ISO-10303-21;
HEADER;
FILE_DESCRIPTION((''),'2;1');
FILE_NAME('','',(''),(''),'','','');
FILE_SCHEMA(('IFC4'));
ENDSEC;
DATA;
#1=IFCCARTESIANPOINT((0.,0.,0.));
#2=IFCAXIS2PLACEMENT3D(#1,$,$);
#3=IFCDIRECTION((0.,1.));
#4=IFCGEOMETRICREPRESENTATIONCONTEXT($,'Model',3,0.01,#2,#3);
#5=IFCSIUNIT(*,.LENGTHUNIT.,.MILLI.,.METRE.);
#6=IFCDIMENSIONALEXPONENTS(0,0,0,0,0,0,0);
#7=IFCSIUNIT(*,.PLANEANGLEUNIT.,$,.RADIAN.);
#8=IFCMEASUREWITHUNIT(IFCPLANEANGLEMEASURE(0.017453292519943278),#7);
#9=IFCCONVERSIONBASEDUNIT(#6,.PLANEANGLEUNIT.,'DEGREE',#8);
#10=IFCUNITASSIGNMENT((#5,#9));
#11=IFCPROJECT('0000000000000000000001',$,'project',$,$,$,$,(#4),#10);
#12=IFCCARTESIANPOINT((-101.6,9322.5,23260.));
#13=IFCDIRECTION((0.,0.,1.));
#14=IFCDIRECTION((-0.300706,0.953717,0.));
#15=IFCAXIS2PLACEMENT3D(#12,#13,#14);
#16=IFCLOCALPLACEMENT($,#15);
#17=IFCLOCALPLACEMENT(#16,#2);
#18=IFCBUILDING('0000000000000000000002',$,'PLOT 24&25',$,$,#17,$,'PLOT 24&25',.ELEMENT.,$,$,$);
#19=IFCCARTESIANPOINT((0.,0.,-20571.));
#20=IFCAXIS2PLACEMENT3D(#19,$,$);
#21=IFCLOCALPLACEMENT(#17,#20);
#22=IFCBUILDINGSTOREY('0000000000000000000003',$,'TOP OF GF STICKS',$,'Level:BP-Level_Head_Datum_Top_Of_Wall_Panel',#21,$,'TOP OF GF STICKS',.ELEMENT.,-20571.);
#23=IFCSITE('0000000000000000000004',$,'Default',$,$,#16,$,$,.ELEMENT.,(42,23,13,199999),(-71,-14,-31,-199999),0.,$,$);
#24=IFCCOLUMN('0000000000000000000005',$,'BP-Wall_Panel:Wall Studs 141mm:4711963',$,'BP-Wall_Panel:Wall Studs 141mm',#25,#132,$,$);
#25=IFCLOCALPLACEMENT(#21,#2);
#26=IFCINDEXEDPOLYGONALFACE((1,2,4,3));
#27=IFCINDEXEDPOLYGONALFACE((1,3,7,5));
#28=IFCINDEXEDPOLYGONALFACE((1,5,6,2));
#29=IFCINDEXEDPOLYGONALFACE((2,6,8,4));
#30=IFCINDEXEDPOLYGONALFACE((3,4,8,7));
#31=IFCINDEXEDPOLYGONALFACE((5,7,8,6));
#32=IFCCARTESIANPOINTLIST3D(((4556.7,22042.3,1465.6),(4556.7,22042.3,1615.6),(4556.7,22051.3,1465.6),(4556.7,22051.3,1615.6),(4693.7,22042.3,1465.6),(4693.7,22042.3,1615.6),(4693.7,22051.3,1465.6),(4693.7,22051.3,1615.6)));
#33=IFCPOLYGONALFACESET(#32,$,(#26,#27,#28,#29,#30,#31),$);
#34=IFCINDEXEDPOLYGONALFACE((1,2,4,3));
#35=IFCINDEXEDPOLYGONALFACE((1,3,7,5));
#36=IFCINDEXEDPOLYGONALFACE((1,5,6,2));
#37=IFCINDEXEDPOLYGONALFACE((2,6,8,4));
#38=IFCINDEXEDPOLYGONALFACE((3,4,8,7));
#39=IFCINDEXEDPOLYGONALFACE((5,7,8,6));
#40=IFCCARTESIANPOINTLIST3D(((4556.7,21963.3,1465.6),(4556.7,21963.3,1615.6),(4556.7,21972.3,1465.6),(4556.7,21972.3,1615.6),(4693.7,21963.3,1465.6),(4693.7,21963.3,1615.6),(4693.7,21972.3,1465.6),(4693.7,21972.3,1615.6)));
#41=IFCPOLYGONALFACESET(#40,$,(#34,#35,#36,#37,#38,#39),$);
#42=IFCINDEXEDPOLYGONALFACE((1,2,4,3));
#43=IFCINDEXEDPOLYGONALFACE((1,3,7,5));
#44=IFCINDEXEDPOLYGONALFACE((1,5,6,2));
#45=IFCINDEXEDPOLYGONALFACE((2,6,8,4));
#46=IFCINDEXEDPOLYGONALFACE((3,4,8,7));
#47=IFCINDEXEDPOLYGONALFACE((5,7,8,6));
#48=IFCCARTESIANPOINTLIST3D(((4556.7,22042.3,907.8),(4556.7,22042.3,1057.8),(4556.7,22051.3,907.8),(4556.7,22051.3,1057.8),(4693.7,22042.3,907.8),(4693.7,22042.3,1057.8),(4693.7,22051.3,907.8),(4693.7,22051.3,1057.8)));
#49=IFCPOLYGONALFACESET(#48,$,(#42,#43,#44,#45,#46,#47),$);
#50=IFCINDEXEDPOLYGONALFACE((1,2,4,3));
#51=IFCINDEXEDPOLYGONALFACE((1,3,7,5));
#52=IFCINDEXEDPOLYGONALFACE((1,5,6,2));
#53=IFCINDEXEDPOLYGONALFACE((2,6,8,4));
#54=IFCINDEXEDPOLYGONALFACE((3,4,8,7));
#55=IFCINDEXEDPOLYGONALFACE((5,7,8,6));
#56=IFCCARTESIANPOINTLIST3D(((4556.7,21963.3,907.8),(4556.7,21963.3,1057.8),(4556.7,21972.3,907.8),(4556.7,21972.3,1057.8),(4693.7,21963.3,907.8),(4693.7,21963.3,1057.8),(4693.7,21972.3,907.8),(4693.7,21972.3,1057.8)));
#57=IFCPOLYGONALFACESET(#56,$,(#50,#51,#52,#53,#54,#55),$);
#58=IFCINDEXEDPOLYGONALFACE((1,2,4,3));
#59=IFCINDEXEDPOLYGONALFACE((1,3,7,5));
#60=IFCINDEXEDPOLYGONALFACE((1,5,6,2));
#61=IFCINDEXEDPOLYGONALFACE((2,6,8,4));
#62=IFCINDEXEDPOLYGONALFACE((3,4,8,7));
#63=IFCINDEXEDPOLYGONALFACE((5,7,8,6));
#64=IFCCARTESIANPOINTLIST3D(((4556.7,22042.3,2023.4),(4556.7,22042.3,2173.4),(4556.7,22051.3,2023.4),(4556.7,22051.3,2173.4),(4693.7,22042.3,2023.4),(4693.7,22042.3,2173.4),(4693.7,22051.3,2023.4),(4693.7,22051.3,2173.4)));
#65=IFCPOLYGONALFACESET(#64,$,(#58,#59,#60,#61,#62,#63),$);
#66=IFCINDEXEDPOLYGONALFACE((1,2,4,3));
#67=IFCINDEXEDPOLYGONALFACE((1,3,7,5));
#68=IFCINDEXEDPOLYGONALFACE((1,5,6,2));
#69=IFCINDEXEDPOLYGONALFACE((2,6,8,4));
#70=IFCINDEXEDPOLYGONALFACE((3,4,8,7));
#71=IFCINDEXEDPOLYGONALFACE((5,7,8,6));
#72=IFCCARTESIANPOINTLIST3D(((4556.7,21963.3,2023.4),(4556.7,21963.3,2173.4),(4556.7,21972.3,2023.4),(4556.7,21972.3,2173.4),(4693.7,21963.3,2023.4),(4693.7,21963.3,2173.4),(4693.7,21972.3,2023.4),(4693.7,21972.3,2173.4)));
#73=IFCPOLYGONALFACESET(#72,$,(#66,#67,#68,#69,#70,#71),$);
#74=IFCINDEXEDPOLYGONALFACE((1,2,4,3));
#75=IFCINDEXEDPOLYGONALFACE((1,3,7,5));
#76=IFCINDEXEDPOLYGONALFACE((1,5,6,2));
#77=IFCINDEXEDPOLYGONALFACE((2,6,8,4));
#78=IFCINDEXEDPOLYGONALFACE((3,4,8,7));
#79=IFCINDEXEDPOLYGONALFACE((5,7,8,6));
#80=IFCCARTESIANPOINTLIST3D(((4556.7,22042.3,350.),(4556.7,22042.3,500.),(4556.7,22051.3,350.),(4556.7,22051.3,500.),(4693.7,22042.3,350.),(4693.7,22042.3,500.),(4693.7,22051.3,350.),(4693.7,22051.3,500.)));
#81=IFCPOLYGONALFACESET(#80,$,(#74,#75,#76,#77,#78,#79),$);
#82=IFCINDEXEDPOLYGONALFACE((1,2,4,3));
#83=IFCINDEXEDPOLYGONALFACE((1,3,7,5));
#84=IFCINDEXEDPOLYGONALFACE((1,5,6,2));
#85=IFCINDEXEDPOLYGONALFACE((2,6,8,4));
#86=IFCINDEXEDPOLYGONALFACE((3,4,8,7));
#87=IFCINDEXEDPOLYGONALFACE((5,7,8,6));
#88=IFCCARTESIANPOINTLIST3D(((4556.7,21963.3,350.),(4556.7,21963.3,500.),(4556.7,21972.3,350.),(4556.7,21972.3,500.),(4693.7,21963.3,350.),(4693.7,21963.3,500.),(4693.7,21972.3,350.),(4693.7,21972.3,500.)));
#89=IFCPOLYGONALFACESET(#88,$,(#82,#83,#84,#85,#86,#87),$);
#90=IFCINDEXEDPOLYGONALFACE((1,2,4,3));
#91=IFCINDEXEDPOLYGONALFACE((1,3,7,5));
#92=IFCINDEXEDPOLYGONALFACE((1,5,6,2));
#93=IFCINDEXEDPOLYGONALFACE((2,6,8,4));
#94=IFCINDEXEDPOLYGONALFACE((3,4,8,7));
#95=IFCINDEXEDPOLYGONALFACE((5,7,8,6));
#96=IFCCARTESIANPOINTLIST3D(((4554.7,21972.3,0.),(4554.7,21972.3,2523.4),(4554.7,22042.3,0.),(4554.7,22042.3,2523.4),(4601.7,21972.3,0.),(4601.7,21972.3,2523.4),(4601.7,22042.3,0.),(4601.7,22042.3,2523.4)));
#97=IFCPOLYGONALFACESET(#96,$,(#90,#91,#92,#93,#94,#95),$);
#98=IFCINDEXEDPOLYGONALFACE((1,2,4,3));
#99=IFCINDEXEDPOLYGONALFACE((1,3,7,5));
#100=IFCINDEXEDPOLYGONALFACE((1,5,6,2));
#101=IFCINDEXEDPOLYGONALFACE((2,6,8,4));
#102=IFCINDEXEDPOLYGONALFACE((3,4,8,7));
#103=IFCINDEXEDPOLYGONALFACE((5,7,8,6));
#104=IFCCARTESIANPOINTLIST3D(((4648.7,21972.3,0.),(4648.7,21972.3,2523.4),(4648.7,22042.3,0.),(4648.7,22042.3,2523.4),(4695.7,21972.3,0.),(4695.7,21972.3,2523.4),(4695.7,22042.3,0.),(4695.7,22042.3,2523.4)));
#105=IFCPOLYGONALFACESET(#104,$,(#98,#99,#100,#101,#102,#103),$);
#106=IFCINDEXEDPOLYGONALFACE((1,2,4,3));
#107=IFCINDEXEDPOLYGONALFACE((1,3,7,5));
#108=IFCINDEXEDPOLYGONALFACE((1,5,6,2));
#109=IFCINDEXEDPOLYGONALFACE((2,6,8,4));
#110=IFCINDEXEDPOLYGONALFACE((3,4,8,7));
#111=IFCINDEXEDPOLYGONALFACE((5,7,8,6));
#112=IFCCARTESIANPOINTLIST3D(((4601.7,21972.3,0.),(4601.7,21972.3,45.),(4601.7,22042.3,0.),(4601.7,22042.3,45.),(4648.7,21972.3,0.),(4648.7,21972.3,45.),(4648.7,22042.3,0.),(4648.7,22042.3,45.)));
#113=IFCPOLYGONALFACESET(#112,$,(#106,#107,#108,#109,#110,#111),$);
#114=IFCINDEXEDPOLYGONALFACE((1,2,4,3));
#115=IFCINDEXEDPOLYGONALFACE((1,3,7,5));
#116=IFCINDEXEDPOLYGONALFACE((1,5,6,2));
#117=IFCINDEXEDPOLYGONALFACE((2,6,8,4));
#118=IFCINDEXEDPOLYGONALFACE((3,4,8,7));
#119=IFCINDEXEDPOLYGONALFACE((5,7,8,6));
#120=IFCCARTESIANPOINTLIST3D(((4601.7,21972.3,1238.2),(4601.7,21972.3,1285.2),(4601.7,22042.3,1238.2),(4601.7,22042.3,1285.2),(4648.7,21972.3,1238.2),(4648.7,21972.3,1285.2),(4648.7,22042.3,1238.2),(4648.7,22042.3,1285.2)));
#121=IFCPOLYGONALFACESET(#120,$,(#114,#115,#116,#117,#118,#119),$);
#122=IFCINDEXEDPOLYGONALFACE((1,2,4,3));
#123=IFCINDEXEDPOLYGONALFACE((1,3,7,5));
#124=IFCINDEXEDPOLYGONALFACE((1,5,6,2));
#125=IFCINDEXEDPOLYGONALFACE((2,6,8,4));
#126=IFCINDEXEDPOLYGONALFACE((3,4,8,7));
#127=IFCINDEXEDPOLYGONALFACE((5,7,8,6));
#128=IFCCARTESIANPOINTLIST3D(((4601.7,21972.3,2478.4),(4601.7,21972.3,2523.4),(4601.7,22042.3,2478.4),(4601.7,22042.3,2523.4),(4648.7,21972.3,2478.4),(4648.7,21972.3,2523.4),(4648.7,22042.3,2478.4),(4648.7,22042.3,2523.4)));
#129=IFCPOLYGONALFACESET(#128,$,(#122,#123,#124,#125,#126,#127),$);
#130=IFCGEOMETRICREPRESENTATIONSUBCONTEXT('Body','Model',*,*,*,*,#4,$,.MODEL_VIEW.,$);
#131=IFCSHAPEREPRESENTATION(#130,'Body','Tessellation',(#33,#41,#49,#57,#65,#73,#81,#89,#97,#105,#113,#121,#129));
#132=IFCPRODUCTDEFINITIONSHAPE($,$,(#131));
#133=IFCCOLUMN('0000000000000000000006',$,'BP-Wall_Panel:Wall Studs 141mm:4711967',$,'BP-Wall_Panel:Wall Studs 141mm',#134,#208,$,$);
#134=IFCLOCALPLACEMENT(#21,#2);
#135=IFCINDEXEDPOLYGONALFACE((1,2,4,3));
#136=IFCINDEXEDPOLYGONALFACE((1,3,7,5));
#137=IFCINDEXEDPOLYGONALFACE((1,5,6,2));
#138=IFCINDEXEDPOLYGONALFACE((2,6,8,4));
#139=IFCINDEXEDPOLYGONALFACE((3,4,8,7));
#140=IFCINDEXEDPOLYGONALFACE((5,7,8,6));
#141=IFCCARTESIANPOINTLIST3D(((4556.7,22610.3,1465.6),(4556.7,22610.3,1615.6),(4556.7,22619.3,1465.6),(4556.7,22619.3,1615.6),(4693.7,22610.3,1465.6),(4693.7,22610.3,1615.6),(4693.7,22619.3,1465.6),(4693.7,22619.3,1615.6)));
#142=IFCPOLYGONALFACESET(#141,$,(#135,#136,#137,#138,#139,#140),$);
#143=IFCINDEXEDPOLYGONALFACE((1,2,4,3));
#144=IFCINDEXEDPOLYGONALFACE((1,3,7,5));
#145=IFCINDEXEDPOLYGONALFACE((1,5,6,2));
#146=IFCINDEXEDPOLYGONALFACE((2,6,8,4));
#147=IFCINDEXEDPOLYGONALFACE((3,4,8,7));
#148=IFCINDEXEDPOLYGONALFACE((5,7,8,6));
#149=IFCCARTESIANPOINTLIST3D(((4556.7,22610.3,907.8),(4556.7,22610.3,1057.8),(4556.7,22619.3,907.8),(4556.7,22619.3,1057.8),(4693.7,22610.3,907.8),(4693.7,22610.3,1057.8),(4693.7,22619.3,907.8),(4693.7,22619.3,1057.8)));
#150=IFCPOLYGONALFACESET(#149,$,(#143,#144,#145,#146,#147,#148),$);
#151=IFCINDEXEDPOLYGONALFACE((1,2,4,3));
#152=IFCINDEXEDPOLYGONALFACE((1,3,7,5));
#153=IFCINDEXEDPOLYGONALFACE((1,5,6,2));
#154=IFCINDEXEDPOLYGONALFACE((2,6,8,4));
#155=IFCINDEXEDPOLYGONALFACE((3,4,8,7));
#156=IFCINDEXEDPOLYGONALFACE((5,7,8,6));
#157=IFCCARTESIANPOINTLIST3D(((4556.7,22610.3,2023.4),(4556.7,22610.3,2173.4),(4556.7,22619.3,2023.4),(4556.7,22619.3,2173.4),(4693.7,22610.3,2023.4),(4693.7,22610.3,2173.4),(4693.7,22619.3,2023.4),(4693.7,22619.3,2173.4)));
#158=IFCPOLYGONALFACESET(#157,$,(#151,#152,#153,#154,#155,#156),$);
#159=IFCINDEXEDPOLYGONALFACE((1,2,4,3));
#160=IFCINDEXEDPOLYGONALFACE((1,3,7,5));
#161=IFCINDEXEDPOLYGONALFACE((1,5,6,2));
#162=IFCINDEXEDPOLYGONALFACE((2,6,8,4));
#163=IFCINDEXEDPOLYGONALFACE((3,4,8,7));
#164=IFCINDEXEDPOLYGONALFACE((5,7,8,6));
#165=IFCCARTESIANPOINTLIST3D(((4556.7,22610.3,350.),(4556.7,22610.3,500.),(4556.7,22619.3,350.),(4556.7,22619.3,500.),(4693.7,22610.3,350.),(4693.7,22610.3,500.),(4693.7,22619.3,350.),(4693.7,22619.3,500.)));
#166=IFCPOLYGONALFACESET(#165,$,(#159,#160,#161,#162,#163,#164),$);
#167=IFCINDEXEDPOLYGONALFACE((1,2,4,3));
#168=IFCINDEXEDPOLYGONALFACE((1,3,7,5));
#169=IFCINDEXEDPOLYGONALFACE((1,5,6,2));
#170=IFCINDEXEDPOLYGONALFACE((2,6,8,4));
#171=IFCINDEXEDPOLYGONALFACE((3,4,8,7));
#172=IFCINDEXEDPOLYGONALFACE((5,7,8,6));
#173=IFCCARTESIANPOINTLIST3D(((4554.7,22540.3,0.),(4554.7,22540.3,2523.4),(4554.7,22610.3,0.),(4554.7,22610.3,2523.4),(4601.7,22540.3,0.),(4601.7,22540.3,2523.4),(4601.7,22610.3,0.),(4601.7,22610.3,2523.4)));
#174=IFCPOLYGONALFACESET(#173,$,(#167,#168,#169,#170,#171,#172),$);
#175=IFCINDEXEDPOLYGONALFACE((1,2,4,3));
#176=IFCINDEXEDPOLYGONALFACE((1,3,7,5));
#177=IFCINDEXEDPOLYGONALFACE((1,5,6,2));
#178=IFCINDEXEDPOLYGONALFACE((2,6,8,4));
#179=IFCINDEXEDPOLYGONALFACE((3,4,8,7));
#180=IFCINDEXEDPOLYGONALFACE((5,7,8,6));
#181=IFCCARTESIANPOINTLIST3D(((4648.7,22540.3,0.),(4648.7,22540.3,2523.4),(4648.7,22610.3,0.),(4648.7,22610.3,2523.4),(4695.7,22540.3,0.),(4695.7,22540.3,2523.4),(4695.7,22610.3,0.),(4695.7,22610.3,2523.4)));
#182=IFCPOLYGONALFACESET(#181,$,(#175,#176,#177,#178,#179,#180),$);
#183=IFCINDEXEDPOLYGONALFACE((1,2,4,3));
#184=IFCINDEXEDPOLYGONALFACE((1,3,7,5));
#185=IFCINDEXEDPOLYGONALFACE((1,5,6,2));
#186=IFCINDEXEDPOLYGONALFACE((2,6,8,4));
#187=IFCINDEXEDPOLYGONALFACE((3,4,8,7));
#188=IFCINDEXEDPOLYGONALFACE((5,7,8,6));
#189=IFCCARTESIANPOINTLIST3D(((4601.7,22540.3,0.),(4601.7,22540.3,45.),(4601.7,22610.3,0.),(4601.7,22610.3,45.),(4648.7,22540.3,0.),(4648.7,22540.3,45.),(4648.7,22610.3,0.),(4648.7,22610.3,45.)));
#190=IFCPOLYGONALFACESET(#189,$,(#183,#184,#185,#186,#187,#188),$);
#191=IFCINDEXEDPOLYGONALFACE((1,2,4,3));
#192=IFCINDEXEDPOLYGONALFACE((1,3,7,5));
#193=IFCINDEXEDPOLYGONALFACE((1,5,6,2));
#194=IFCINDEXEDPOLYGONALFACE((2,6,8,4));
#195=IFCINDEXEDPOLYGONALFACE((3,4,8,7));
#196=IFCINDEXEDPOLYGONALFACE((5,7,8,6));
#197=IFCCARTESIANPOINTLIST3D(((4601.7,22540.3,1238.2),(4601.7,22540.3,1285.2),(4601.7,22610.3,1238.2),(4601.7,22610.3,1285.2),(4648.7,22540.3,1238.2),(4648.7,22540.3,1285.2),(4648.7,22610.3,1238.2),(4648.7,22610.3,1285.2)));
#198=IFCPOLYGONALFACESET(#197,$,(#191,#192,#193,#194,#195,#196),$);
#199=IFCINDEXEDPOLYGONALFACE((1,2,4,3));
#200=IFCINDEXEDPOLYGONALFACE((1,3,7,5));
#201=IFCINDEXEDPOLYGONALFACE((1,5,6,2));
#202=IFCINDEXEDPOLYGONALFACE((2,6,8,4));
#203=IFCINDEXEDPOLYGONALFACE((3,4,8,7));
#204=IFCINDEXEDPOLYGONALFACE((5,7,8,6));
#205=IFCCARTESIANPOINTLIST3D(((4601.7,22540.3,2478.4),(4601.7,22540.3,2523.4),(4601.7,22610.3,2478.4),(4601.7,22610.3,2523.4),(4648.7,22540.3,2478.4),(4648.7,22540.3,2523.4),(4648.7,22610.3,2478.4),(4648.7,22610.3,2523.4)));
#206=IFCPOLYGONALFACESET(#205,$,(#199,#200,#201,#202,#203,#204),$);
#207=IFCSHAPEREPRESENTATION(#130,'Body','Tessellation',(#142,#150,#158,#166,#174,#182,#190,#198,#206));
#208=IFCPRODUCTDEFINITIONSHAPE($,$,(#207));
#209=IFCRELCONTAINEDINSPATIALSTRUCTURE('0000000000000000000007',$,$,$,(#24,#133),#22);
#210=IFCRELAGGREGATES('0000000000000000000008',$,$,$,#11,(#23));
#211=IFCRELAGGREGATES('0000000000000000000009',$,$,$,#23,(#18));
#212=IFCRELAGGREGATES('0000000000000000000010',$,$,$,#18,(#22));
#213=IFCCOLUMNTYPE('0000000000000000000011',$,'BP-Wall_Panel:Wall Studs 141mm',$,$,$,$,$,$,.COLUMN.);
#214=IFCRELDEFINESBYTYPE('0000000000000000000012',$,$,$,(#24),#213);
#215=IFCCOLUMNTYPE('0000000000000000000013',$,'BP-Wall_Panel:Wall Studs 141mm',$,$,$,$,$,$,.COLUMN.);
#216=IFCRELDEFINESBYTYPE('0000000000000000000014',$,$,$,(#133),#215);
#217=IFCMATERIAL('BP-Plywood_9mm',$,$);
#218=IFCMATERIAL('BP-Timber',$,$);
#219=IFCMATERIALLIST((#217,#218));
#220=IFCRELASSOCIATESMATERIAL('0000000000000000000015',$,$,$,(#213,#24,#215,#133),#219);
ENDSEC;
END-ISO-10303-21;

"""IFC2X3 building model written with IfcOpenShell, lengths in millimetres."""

from ifc_helpers import new_model, entity, si_unit, converted_unit, direction, frame, frame_2d, origin, origin_2d_with_axis, place, context, subcontext, project, spatial, rectangle, extrude, source, transform, mapped, material, material_list, type_object, type_shapes, element, save


model = new_model("IFC2X3")

# Units and contexts
model_context = context("Model", 3, precision=0.01, world=origin(), true_north=direction((0.0, 1.0)))
body_context = subcontext(model_context, "Body", "Model", "MODEL_VIEW")
ifc_project = project(units=[si_unit("LENGTHUNIT", "METRE", prefix="MILLI"), converted_unit("PLANEANGLEUNIT", "DEGREE", entity("IfcPlaneAngleMeasure", 0.017453292519943278), si_unit("PLANEANGLEUNIT", "RADIAN"), dimensions=[0, 0, 0, 0, 0, 0, 0])], contexts=[model_context])

# Site, building, storey
site_placement = place(None, frame((-101.6, 9322.5, 23260.0), z_axis=(0.0, 0.0, 1.0), x_axis=(-0.300706, 0.953717, 0.0)))
site = spatial("IfcSite", under=ifc_project, at=site_placement, Name="Default", CompositionType="ELEMENT", RefLatitude=(42, 23, 13, 199999), RefLongitude=(-71, -14, -31, -199999), RefElevation=0.0)
building_placement = place(site_placement, origin())
building = spatial("IfcBuilding", under=site, at=building_placement, Name="PLOT 24&25", LongName="PLOT 24&25", CompositionType="ELEMENT")
storey_placement = place(building_placement, frame((0.0, 0.0, -20571.0)))
storey = spatial("IfcBuildingStorey", under=building, at=storey_placement, Name="TOP OF GF STICKS", ObjectType="Level:BP-Level_Head_Datum_Top_Of_Wall_Panel", LongName="TOP OF GF STICKS", CompositionType="ELEMENT", Elevation=-20571.0)

# Columns
ifc_material_1 = material(Name="BP-Plywood_9mm")
ifc_material_2 = material(Name="BP-Timber")
ifc_material_list = material_list([ifc_material_1, ifc_material_2])
column_type_1 = type_object("IfcColumnType", Name="BP-Wall_Panel:Wall Studs 141mm", PredefinedType="COLUMN", material=ifc_material_list)
shared_shape_1 = source(origin(), body_context, "Body", "SweptSolid", [
    extrude(rectangle(XDim=9.0, YDim=137.0, at=origin_2d_with_axis()), frame((39.5, 0.0, -19105.4)), (0.0, 0.0, 1.0), 150.0),
    extrude(rectangle(XDim=137.0, YDim=9.0, at=origin_2d_with_axis()), frame((-39.5, 0.0, -19105.4), z_axis=(0.0, 0.0, 1.0), x_axis=(0.0, 1.0, 0.0)), (0.0, 0.0, 1.0), 150.0),
    extrude(rectangle(XDim=9.0, YDim=137.0, at=origin_2d_with_axis()), frame((39.5, 0.0, -19663.2)), (0.0, 0.0, 1.0), 150.0),
    extrude(rectangle(XDim=137.0, YDim=9.0, at=origin_2d_with_axis()), frame((-39.5, 0.0, -19663.2), z_axis=(0.0, 0.0, 1.0), x_axis=(0.0, 1.0, 0.0)), (0.0, 0.0, 1.0), 150.0),
    extrude(rectangle(XDim=9.0, YDim=137.0, at=frame_2d((0.0, 0.0), x_axis=(1.0, 0.0))), frame((39.5, 0.0, -18547.6)), (0.0, 0.0, 1.0), 150.0),
    extrude(rectangle(XDim=137.0, YDim=9.0, at=origin_2d_with_axis()), frame((-39.5, 0.0, -18547.6), z_axis=(0.0, 0.0, 1.0), x_axis=(0.0, 1.0, 0.0)), (0.0, 0.0, 1.0), 150.0),
    extrude(rectangle(XDim=9.0, YDim=137.0, at=origin_2d_with_axis()), frame((39.5, 0.0, -20221.0)), (0.0, 0.0, 1.0), 150.0),
    extrude(rectangle(XDim=137.0, YDim=9.0, at=origin_2d_with_axis()), frame((-39.5, 0.0, -20221.0), z_axis=(0.0, 0.0, 1.0), x_axis=(0.0, 1.0, 0.0)), (0.0, 0.0, 1.0), 150.0),
    extrude(rectangle(XDim=47.0, YDim=70.0, at=origin_2d_with_axis()), frame((0.0, 47.0, -20571.0), z_axis=(0.0, 0.0, 1.0), x_axis=(0.0, 1.0, 0.0)), (0.0, 0.0, 1.0), 2523.4),
    extrude(rectangle(XDim=47.0, YDim=70.0, at=origin_2d_with_axis()), frame((0.0, -47.0, -20571.0), z_axis=(0.0, 0.0, 1.0), x_axis=(0.0, 1.0, 0.0)), (0.0, 0.0, 1.0), 2523.4),
    extrude(rectangle(XDim=70.0, YDim=47.0, at=origin_2d_with_axis()), frame((0.0, 0.0, -20571.0)), (0.0, 0.0, 1.0), 45.0),
    extrude(rectangle(XDim=70.0, YDim=47.0, at=origin_2d_with_axis()), frame((0.0, 0.0, -19332.8)), (0.0, 0.0, 1.0), 47.0),
    extrude(rectangle(XDim=70.0, YDim=47.0, at=origin_2d_with_axis()), frame((0.0, 0.0, -18092.6)), (0.0, 0.0, 1.0), 45.0),
])
type_shapes(column_type_1, [shared_shape_1])
for number, where, z_axis, x_axis, name in (
    (1, (4625.2, 22007.3, 20571.0), (0.0, 0.0, 1.0), (0.0, 1.0, 0.0), "BP-Wall_Panel:Wall Studs 141mm:4711963"),
):
    element("IfcColumn", number, at=place(storey_placement, frame(where, z_axis=z_axis, x_axis=x_axis)), inside=storey, type_object=column_type_1, material=ifc_material_list, Name=name, ObjectType="BP-Wall_Panel:Wall Studs 141mm", context=body_context, shape_type="MappedRepresentation", body=[
        mapped(shared_shape_1, transform((0.0, 0.0, 0.0), scale=1.0)),
    ])
column_type_2 = type_object("IfcColumnType", Name="BP-Wall_Panel:Wall Studs 141mm", PredefinedType="COLUMN", material=ifc_material_list)
shared_shape_2 = source(origin(), body_context, "Body", "SweptSolid", [
    extrude(rectangle(XDim=9.0, YDim=137.0, at=origin_2d_with_axis()), frame((39.5, 0.0, -19105.4)), (0.0, 0.0, 1.0), 150.0),
    extrude(rectangle(XDim=9.0, YDim=137.0, at=origin_2d_with_axis()), frame((39.5, 0.0, -19663.2)), (0.0, 0.0, 1.0), 150.0),
    extrude(rectangle(XDim=9.0, YDim=137.0, at=frame_2d((0.0, 0.0), x_axis=(1.0, 0.0))), frame((39.5, 0.0, -18547.6)), (0.0, 0.0, 1.0), 150.0),
    extrude(rectangle(XDim=9.0, YDim=137.0, at=origin_2d_with_axis()), frame((39.5, 0.0, -20221.0)), (0.0, 0.0, 1.0), 150.0),
    extrude(rectangle(XDim=47.0, YDim=70.0, at=origin_2d_with_axis()), frame((0.0, 47.0, -20571.0), z_axis=(0.0, 0.0, 1.0), x_axis=(0.0, 1.0, 0.0)), (0.0, 0.0, 1.0), 2523.4),
    extrude(rectangle(XDim=47.0, YDim=70.0, at=origin_2d_with_axis()), frame((0.0, -47.0, -20571.0), z_axis=(0.0, 0.0, 1.0), x_axis=(0.0, 1.0, 0.0)), (0.0, 0.0, 1.0), 2523.4),
    extrude(rectangle(XDim=70.0, YDim=47.0, at=origin_2d_with_axis()), frame((0.0, 0.0, -20571.0)), (0.0, 0.0, 1.0), 45.0),
    extrude(rectangle(XDim=70.0, YDim=47.0, at=origin_2d_with_axis()), frame((0.0, 0.0, -19332.8)), (0.0, 0.0, 1.0), 47.0),
    extrude(rectangle(XDim=70.0, YDim=47.0, at=origin_2d_with_axis()), frame((0.0, 0.0, -18092.6)), (0.0, 0.0, 1.0), 45.0),
])
type_shapes(column_type_2, [shared_shape_2])
for number, where, z_axis, x_axis, name in (
    (2, (4625.2, 22575.3, 20571.0), (0.0, 0.0, 1.0), (0.0, 1.0, 0.0), "BP-Wall_Panel:Wall Studs 141mm:4711967"),
):
    element("IfcColumn", number, at=place(storey_placement, frame(where, z_axis=z_axis, x_axis=x_axis)), inside=storey, type_object=column_type_2, material=ifc_material_list, Name=name, ObjectType="BP-Wall_Panel:Wall Studs 141mm", context=body_context, shape_type="MappedRepresentation", body=[
        mapped(shared_shape_2, transform((0.0, 0.0, 0.0), scale=1.0)),
    ])

save(model, "model.ifc")
